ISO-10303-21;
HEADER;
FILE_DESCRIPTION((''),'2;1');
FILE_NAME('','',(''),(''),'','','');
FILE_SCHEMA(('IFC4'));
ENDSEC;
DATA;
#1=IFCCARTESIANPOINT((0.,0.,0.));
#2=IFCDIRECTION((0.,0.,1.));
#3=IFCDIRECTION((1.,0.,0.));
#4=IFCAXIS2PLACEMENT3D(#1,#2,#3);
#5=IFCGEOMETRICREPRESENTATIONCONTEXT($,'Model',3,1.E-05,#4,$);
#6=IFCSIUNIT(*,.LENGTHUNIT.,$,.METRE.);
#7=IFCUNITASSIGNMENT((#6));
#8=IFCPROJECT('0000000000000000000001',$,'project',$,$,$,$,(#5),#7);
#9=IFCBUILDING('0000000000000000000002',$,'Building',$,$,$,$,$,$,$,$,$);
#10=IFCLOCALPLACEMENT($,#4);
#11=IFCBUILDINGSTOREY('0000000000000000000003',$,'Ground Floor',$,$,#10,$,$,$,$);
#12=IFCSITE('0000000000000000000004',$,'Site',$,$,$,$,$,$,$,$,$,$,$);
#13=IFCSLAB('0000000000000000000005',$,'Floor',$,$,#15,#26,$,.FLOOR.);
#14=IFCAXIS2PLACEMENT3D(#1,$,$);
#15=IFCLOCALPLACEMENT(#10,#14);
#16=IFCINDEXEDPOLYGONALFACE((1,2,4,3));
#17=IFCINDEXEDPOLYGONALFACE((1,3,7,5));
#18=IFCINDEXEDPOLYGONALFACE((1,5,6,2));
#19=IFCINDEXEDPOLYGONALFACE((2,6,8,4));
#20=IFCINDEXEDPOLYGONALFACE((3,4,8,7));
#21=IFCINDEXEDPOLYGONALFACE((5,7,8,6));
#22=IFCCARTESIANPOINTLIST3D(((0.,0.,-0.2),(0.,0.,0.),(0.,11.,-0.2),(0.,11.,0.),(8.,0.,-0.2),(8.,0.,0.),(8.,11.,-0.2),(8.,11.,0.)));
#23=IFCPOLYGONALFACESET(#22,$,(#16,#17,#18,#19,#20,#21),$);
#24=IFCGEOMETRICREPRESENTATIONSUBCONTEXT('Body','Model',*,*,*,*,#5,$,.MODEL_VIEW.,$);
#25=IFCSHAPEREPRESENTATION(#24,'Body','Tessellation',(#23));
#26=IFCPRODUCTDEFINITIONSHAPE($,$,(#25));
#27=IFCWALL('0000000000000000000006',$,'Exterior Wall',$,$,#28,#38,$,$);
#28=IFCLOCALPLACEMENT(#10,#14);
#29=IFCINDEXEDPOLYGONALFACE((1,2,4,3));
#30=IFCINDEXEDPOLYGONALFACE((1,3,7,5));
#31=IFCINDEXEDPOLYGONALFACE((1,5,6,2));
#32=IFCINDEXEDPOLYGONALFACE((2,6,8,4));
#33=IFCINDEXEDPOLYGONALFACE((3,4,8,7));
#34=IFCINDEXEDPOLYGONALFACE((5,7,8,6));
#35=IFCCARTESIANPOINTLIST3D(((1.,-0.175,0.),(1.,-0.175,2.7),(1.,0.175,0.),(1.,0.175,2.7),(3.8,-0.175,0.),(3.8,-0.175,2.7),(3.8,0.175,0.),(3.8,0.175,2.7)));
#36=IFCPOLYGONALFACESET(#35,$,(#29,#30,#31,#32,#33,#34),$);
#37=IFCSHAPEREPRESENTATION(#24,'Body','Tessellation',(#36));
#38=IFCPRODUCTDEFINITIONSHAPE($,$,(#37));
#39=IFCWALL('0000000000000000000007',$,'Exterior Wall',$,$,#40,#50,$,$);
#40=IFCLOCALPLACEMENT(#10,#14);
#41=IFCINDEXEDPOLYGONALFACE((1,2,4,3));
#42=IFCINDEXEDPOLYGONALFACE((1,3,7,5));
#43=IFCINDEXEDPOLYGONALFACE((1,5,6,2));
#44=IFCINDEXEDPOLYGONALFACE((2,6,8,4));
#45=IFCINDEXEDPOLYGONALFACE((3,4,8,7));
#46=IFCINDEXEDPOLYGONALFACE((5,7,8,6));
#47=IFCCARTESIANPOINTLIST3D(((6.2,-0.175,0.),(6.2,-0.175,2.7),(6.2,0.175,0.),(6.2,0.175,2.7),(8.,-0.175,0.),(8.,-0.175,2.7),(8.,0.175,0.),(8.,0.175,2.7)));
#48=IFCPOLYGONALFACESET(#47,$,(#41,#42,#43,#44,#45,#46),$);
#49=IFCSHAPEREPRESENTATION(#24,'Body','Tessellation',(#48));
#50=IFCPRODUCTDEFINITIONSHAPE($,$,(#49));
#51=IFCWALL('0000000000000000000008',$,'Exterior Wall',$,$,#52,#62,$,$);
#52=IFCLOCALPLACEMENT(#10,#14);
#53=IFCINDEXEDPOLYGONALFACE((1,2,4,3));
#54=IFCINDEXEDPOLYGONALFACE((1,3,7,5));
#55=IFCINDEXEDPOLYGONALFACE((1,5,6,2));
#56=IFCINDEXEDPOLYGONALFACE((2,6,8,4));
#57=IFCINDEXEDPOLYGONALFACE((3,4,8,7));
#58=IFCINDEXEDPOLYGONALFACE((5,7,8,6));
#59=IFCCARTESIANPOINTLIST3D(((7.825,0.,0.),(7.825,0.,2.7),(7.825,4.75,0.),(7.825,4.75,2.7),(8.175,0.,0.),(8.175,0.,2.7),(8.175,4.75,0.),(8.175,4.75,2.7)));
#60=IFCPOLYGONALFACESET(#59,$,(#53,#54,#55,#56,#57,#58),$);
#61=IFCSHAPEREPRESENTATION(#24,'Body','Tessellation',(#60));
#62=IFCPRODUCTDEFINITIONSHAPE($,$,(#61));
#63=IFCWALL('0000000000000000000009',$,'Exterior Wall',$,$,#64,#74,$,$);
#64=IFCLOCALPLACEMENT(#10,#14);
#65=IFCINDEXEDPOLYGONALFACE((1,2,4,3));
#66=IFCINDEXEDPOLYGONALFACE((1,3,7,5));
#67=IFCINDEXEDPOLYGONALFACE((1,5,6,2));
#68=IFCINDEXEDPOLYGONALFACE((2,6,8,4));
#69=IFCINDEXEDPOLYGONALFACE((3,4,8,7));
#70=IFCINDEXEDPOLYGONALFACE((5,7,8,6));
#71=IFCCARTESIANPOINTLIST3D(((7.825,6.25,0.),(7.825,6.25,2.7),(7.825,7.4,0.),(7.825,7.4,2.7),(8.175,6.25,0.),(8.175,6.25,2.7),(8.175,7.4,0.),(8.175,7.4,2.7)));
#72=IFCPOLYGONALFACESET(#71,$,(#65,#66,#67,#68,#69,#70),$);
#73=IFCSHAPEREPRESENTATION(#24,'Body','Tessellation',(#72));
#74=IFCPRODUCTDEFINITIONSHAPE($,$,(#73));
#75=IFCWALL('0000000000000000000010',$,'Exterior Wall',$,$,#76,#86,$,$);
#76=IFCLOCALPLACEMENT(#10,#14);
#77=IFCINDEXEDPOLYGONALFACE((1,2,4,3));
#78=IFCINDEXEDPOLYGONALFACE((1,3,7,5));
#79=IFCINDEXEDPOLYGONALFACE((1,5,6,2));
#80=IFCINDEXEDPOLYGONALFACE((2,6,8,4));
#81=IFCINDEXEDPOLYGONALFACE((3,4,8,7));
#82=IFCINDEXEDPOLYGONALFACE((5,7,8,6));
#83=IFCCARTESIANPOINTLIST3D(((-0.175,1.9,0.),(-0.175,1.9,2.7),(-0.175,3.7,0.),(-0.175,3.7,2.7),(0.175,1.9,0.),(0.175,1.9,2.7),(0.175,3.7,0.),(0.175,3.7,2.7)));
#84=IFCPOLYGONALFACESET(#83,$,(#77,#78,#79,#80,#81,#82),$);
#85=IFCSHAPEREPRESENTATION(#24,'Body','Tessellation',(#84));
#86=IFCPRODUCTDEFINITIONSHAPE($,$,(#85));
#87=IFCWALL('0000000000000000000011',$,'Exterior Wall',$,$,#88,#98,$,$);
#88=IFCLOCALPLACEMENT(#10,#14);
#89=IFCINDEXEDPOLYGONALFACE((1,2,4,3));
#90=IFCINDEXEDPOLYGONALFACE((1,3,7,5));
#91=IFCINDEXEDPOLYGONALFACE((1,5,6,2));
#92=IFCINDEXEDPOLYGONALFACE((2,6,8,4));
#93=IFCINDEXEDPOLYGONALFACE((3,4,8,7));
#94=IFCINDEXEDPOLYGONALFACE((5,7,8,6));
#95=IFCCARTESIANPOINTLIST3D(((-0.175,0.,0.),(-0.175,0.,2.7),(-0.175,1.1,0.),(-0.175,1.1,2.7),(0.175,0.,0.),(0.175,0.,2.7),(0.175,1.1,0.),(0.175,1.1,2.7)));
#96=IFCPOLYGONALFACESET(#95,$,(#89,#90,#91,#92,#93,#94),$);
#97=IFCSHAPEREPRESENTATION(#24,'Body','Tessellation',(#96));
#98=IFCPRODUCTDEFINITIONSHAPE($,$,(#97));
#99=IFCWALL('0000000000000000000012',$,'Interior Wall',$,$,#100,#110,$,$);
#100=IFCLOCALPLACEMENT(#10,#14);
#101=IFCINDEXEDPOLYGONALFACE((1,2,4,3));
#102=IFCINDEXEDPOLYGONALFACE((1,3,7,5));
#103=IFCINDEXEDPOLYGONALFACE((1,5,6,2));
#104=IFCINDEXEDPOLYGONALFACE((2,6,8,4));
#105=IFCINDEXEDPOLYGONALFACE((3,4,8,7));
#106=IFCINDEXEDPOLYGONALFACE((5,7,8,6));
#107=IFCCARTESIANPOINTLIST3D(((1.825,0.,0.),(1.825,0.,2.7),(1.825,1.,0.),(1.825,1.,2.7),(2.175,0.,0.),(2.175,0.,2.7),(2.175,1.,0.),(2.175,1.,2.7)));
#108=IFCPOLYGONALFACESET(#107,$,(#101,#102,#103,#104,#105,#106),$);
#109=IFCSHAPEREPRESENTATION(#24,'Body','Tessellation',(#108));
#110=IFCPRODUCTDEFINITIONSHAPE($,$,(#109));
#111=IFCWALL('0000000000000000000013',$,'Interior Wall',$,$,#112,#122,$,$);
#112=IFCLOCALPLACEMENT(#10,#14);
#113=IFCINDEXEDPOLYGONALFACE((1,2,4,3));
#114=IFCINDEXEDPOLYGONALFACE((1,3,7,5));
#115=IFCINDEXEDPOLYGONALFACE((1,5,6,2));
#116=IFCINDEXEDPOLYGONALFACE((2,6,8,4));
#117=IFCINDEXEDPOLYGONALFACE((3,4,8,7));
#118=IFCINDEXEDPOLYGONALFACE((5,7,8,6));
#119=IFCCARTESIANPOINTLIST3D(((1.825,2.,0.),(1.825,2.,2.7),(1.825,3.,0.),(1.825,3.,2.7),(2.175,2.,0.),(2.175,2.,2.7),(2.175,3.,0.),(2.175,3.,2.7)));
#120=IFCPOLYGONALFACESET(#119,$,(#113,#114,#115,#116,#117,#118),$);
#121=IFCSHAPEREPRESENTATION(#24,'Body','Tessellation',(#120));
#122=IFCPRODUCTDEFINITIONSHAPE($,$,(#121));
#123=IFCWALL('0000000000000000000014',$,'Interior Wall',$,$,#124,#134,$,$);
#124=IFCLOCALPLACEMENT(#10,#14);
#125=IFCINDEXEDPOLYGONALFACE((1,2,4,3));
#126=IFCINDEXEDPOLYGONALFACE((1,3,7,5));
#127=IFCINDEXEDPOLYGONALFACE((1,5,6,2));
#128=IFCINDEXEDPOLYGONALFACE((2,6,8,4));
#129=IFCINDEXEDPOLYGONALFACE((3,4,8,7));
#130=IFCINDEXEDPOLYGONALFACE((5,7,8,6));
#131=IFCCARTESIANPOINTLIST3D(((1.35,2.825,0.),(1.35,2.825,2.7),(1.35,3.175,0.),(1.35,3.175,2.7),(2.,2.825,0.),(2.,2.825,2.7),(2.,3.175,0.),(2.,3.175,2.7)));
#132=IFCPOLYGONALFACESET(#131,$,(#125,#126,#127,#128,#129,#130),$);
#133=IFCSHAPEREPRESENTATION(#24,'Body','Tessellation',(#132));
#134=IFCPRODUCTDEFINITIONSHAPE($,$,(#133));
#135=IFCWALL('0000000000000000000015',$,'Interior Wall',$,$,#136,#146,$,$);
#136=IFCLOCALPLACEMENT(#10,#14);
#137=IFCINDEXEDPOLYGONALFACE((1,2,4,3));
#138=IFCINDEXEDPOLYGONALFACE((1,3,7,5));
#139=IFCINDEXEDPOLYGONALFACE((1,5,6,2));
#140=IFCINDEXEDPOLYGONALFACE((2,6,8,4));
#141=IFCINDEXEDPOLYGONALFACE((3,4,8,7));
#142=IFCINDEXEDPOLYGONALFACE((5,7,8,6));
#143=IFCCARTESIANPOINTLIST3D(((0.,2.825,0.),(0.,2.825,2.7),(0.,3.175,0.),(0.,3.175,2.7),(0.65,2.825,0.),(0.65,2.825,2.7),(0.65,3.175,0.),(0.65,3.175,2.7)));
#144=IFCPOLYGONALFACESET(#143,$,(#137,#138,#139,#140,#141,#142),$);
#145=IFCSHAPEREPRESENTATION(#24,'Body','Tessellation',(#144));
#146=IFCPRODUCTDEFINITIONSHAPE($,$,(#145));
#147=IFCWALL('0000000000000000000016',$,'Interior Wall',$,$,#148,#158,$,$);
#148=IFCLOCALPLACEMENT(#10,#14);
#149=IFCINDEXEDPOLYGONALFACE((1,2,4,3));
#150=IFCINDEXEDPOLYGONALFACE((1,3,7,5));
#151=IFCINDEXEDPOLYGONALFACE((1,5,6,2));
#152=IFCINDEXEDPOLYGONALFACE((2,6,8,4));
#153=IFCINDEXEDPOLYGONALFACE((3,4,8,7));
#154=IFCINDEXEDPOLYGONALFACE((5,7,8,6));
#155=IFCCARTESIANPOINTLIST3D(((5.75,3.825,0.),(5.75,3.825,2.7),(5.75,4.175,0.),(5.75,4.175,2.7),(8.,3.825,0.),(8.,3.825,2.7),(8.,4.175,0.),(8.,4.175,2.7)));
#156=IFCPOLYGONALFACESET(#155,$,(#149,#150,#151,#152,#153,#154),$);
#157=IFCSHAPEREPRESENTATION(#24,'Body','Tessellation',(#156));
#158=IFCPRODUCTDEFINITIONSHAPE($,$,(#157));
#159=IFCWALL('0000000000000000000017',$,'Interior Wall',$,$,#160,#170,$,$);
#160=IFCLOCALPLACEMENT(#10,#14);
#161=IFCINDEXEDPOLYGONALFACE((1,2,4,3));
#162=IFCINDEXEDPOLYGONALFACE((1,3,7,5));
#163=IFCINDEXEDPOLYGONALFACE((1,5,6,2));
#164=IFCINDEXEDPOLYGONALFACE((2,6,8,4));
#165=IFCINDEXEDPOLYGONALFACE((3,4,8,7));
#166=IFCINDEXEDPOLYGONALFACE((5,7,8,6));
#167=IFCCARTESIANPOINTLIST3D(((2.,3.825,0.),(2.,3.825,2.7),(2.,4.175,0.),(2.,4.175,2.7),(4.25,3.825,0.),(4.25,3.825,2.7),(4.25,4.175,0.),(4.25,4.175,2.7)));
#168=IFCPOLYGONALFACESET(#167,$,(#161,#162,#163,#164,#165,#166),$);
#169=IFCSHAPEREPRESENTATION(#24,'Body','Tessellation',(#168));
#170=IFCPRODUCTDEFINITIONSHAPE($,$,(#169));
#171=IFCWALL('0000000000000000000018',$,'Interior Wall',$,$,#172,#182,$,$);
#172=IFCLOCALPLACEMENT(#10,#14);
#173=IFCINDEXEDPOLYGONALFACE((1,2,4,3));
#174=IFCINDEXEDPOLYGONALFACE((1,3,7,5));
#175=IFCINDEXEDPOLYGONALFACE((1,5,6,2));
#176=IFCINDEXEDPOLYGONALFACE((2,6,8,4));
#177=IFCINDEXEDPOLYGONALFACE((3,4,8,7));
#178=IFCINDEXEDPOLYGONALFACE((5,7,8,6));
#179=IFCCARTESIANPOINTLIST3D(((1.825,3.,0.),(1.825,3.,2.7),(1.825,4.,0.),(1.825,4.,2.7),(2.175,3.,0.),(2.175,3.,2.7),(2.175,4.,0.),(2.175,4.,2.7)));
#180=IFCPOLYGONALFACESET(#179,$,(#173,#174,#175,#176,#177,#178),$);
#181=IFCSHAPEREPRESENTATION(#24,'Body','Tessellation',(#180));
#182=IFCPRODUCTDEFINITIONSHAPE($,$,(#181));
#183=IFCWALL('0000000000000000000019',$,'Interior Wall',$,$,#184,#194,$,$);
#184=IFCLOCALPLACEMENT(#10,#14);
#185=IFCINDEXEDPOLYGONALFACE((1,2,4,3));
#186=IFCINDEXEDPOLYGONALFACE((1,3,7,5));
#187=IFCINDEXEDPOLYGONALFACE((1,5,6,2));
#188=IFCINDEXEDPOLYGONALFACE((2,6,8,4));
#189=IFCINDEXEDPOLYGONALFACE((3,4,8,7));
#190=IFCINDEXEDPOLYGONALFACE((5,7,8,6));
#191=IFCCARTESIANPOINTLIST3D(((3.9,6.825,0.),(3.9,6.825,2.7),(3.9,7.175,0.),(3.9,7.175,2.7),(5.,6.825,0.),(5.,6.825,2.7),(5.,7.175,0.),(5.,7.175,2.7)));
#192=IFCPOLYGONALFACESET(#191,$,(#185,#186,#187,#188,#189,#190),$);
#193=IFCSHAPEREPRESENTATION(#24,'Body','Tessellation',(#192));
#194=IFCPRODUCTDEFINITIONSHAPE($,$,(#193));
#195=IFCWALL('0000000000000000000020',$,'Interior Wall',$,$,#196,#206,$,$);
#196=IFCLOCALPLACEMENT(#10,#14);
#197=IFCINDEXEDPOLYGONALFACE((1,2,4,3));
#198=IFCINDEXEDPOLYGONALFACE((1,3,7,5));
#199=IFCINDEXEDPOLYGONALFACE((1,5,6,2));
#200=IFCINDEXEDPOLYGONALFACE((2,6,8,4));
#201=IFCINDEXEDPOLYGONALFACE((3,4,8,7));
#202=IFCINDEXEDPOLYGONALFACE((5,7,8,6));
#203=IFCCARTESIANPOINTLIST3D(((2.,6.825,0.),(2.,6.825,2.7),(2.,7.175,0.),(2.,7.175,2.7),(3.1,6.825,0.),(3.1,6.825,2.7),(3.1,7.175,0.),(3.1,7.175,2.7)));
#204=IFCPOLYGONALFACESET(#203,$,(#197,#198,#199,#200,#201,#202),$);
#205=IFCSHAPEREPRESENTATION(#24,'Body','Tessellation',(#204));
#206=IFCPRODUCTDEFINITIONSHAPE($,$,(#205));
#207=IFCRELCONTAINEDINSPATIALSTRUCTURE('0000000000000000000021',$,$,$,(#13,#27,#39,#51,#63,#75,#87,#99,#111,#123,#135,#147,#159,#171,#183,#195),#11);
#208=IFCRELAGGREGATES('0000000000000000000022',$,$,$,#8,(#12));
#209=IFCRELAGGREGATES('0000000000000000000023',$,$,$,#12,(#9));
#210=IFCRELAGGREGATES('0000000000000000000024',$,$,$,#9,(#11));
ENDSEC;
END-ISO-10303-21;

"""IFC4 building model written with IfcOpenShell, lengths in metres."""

from ifc_helpers import new_model, si_unit, frame, origin_with_axes, place, context, subcontext, project, spatial, indexed_curve, outline, extrude, element, save


model = new_model("IFC4")

# Units and contexts
model_context = context("Model", 3, precision=1e-05, world=origin_with_axes())
body_context = subcontext(model_context, "Body", "Model", "MODEL_VIEW")
ifc_project = project(units=[si_unit("LENGTHUNIT", "METRE")], contexts=[model_context])

# Site, building, storey
site = spatial("IfcSite", under=ifc_project, Name="Site")
building = spatial("IfcBuilding", under=site, Name="Building")
storey_placement = place(None, origin_with_axes())
storey = spatial("IfcBuildingStorey", under=building, at=storey_placement, Name="Ground Floor")

# Slab
slab_placement = place(storey_placement, frame((0.0, 0.0, -0.2), z_axis=(0.0, 0.0, 1.0), x_axis=(1.0, 0.0, 0.0)))
element("IfcSlab", 1, at=slab_placement, inside=storey, Name="Floor", PredefinedType="FLOOR", context=body_context, shape_type="SweptSolid", body=[
    extrude(outline(indexed_curve([(0.0, 0.0), (8.0, 0.0), (8.0, 11.0), (0.0, 11.0)])), None, (0.0, 0.0, 1.0), 0.2),
])

# Walls
wall_1_placement = place(storey_placement, frame((1.0, 0.0, 0.0), z_axis=(0.0, 0.0, 1.0), x_axis=(1.0, 0.0, 0.0)))
element("IfcWall", 2, at=wall_1_placement, inside=storey, Name="Exterior Wall", context=body_context, shape_type="SweptSolid", body=[
    extrude(outline(indexed_curve([(0.0, 0.0), (0.0, 0.35), (2.8, 0.35), (2.8, 0.0), (0.0, 0.0)], self_intersect=False)), frame((0.0, -0.175, 0.0), z_axis=(0.0, 0.0, 1.0), x_axis=(1.0, 0.0, 0.0)), (0.0, 0.0, 1.0), 2.7),
])
wall_2_placement = place(storey_placement, frame((6.2, 0.0, 0.0), z_axis=(0.0, 0.0, 1.0), x_axis=(1.0, 0.0, 0.0)))
element("IfcWall", 3, at=wall_2_placement, inside=storey, Name="Exterior Wall", context=body_context, shape_type="SweptSolid", body=[
    extrude(outline(indexed_curve([(0.0, 0.0), (0.0, 0.35), (1.8, 0.35), (1.8, 0.0), (0.0, 0.0)], self_intersect=False)), frame((0.0, -0.175, 0.0), z_axis=(0.0, 0.0, 1.0), x_axis=(1.0, 0.0, 0.0)), (0.0, 0.0, 1.0), 2.7),
])
wall_3_placement = place(storey_placement, frame((8.0, 0.0, 0.0), z_axis=(0.0, 0.0, 1.0), x_axis=(0.0, 1.0, 0.0)))
element("IfcWall", 4, at=wall_3_placement, inside=storey, Name="Exterior Wall", context=body_context, shape_type="SweptSolid", body=[
    extrude(outline(indexed_curve([(0.0, 0.0), (0.0, 0.35), (4.75, 0.35), (4.75, 0.0), (0.0, 0.0)], self_intersect=False)), frame((0.0, -0.175, 0.0), z_axis=(0.0, 0.0, 1.0), x_axis=(1.0, 0.0, 0.0)), (0.0, 0.0, 1.0), 2.7),
])
wall_4_placement = place(storey_placement, frame((8.0, 6.25, 0.0), z_axis=(0.0, 0.0, 1.0), x_axis=(0.0, 1.0, 0.0)))
element("IfcWall", 5, at=wall_4_placement, inside=storey, Name="Exterior Wall", context=body_context, shape_type="SweptSolid", body=[
    extrude(outline(indexed_curve([(0.0, 0.0), (0.0, 0.35), (1.15, 0.35), (1.15, 0.0), (0.0, 0.0)], self_intersect=False)), frame((0.0, -0.175, 0.0), z_axis=(0.0, 0.0, 1.0), x_axis=(1.0, 0.0, 0.0)), (0.0, 0.0, 1.0), 2.7),
])
wall_5_placement = place(storey_placement, frame((0.0, 3.7, 0.0), z_axis=(0.0, 0.0, 1.0), x_axis=(0.0, -1.0, 0.0)))
element("IfcWall", 6, at=wall_5_placement, inside=storey, Name="Exterior Wall", context=body_context, shape_type="SweptSolid", body=[
    extrude(outline(indexed_curve([(0.0, 0.0), (0.0, 0.35), (1.8, 0.35), (1.8, 0.0), (0.0, 0.0)], self_intersect=False)), frame((0.0, -0.175, 0.0), z_axis=(0.0, 0.0, 1.0), x_axis=(1.0, 0.0, 0.0)), (0.0, 0.0, 1.0), 2.7),
])
wall_6_placement = place(storey_placement, frame((0.0, 1.1, 0.0), z_axis=(0.0, 0.0, 1.0), x_axis=(0.0, -1.0, 0.0)))
element("IfcWall", 7, at=wall_6_placement, inside=storey, Name="Exterior Wall", context=body_context, shape_type="SweptSolid", body=[
    extrude(outline(indexed_curve([(0.0, 0.0), (0.0, 0.35), (1.1, 0.35), (1.1, 0.0), (0.0, 0.0)], self_intersect=False)), frame((0.0, -0.175, 0.0), z_axis=(0.0, 0.0, 1.0), x_axis=(1.0, 0.0, 0.0)), (0.0, 0.0, 1.0), 2.7),
])
for number, where, z_axis, x_axis, name in (
    (8, (2.0, 0.0, 0.0), (0.0, 0.0, 1.0), (0.0, 1.0, 0.0), "Interior Wall"),
    (9, (2.0, 2.0, 0.0), (0.0, 0.0, 1.0), (0.0, 1.0, 0.0), "Interior Wall"),
):
    element("IfcWall", number, at=place(storey_placement, frame(where, z_axis=z_axis, x_axis=x_axis)), inside=storey, Name=name, context=body_context, shape_type="SweptSolid", body=[
        extrude(outline(indexed_curve([(0.0, 0.0), (0.0, 0.35), (1.0, 0.35), (1.0, 0.0), (0.0, 0.0)], self_intersect=False)), frame((0.0, -0.175, 0.0), z_axis=(0.0, 0.0, 1.0), x_axis=(1.0, 0.0, 0.0)), (0.0, 0.0, 1.0), 2.7),
    ])
for number, where, z_axis, x_axis, name in (
    (10, (2.0, 3.0, 0.0), (0.0, 0.0, 1.0), (-1.0, 0.0, 0.0), "Interior Wall"),
    (11, (0.65, 3.0, 0.0), (0.0, 0.0, 1.0), (-1.0, 0.0, 0.0), "Interior Wall"),
):
    element("IfcWall", number, at=place(storey_placement, frame(where, z_axis=z_axis, x_axis=x_axis)), inside=storey, Name=name, context=body_context, shape_type="SweptSolid", body=[
        extrude(outline(indexed_curve([(0.0, 0.0), (0.0, 0.35), (0.65, 0.35), (0.65, 0.0), (0.0, 0.0)], self_intersect=False)), frame((0.0, -0.175, 0.0), z_axis=(0.0, 0.0, 1.0), x_axis=(1.0, 0.0, 0.0)), (0.0, 0.0, 1.0), 2.7),
    ])
for number, where, z_axis, x_axis, name in (
    (12, (8.0, 4.0, 0.0), (0.0, 0.0, 1.0), (-1.0, 0.0, 0.0), "Interior Wall"),
    (13, (4.25, 4.0, 0.0), (0.0, 0.0, 1.0), (-1.0, 0.0, 0.0), "Interior Wall"),
):
    element("IfcWall", number, at=place(storey_placement, frame(where, z_axis=z_axis, x_axis=x_axis)), inside=storey, Name=name, context=body_context, shape_type="SweptSolid", body=[
        extrude(outline(indexed_curve([(0.0, 0.0), (0.0, 0.35), (2.25, 0.35), (2.25, 0.0), (0.0, 0.0)], self_intersect=False)), frame((0.0, -0.175, 0.0), z_axis=(0.0, 0.0, 1.0), x_axis=(1.0, 0.0, 0.0)), (0.0, 0.0, 1.0), 2.7),
    ])
wall_7_placement = place(storey_placement, frame((2.0, 4.0, 0.0), z_axis=(0.0, 0.0, 1.0), x_axis=(0.0, -1.0, 0.0)))
element("IfcWall", 14, at=wall_7_placement, inside=storey, Name="Interior Wall", context=body_context, shape_type="SweptSolid", body=[
    extrude(outline(indexed_curve([(0.0, 0.0), (0.0, 0.35), (1.0, 0.35), (1.0, 0.0), (0.0, 0.0)], self_intersect=False)), frame((0.0, -0.175, 0.0), z_axis=(0.0, 0.0, 1.0), x_axis=(1.0, 0.0, 0.0)), (0.0, 0.0, 1.0), 2.7),
])
for number, where, z_axis, x_axis, name in (
    (15, (5.0, 7.0, 0.0), (0.0, 0.0, 1.0), (-1.0, 0.0, 0.0), "Interior Wall"),
    (16, (3.1, 7.0, 0.0), (0.0, 0.0, 1.0), (-1.0, 0.0, 0.0), "Interior Wall"),
):
    element("IfcWall", number, at=place(storey_placement, frame(where, z_axis=z_axis, x_axis=x_axis)), inside=storey, Name=name, context=body_context, shape_type="SweptSolid", body=[
        extrude(outline(indexed_curve([(0.0, 0.0), (0.0, 0.35), (1.1, 0.35), (1.1, 0.0), (0.0, 0.0)], self_intersect=False)), frame((0.0, -0.175, 0.0), z_axis=(0.0, 0.0, 1.0), x_axis=(1.0, 0.0, 0.0)), (0.0, 0.0, 1.0), 2.7),
    ])

save(model, "model.ifc")
